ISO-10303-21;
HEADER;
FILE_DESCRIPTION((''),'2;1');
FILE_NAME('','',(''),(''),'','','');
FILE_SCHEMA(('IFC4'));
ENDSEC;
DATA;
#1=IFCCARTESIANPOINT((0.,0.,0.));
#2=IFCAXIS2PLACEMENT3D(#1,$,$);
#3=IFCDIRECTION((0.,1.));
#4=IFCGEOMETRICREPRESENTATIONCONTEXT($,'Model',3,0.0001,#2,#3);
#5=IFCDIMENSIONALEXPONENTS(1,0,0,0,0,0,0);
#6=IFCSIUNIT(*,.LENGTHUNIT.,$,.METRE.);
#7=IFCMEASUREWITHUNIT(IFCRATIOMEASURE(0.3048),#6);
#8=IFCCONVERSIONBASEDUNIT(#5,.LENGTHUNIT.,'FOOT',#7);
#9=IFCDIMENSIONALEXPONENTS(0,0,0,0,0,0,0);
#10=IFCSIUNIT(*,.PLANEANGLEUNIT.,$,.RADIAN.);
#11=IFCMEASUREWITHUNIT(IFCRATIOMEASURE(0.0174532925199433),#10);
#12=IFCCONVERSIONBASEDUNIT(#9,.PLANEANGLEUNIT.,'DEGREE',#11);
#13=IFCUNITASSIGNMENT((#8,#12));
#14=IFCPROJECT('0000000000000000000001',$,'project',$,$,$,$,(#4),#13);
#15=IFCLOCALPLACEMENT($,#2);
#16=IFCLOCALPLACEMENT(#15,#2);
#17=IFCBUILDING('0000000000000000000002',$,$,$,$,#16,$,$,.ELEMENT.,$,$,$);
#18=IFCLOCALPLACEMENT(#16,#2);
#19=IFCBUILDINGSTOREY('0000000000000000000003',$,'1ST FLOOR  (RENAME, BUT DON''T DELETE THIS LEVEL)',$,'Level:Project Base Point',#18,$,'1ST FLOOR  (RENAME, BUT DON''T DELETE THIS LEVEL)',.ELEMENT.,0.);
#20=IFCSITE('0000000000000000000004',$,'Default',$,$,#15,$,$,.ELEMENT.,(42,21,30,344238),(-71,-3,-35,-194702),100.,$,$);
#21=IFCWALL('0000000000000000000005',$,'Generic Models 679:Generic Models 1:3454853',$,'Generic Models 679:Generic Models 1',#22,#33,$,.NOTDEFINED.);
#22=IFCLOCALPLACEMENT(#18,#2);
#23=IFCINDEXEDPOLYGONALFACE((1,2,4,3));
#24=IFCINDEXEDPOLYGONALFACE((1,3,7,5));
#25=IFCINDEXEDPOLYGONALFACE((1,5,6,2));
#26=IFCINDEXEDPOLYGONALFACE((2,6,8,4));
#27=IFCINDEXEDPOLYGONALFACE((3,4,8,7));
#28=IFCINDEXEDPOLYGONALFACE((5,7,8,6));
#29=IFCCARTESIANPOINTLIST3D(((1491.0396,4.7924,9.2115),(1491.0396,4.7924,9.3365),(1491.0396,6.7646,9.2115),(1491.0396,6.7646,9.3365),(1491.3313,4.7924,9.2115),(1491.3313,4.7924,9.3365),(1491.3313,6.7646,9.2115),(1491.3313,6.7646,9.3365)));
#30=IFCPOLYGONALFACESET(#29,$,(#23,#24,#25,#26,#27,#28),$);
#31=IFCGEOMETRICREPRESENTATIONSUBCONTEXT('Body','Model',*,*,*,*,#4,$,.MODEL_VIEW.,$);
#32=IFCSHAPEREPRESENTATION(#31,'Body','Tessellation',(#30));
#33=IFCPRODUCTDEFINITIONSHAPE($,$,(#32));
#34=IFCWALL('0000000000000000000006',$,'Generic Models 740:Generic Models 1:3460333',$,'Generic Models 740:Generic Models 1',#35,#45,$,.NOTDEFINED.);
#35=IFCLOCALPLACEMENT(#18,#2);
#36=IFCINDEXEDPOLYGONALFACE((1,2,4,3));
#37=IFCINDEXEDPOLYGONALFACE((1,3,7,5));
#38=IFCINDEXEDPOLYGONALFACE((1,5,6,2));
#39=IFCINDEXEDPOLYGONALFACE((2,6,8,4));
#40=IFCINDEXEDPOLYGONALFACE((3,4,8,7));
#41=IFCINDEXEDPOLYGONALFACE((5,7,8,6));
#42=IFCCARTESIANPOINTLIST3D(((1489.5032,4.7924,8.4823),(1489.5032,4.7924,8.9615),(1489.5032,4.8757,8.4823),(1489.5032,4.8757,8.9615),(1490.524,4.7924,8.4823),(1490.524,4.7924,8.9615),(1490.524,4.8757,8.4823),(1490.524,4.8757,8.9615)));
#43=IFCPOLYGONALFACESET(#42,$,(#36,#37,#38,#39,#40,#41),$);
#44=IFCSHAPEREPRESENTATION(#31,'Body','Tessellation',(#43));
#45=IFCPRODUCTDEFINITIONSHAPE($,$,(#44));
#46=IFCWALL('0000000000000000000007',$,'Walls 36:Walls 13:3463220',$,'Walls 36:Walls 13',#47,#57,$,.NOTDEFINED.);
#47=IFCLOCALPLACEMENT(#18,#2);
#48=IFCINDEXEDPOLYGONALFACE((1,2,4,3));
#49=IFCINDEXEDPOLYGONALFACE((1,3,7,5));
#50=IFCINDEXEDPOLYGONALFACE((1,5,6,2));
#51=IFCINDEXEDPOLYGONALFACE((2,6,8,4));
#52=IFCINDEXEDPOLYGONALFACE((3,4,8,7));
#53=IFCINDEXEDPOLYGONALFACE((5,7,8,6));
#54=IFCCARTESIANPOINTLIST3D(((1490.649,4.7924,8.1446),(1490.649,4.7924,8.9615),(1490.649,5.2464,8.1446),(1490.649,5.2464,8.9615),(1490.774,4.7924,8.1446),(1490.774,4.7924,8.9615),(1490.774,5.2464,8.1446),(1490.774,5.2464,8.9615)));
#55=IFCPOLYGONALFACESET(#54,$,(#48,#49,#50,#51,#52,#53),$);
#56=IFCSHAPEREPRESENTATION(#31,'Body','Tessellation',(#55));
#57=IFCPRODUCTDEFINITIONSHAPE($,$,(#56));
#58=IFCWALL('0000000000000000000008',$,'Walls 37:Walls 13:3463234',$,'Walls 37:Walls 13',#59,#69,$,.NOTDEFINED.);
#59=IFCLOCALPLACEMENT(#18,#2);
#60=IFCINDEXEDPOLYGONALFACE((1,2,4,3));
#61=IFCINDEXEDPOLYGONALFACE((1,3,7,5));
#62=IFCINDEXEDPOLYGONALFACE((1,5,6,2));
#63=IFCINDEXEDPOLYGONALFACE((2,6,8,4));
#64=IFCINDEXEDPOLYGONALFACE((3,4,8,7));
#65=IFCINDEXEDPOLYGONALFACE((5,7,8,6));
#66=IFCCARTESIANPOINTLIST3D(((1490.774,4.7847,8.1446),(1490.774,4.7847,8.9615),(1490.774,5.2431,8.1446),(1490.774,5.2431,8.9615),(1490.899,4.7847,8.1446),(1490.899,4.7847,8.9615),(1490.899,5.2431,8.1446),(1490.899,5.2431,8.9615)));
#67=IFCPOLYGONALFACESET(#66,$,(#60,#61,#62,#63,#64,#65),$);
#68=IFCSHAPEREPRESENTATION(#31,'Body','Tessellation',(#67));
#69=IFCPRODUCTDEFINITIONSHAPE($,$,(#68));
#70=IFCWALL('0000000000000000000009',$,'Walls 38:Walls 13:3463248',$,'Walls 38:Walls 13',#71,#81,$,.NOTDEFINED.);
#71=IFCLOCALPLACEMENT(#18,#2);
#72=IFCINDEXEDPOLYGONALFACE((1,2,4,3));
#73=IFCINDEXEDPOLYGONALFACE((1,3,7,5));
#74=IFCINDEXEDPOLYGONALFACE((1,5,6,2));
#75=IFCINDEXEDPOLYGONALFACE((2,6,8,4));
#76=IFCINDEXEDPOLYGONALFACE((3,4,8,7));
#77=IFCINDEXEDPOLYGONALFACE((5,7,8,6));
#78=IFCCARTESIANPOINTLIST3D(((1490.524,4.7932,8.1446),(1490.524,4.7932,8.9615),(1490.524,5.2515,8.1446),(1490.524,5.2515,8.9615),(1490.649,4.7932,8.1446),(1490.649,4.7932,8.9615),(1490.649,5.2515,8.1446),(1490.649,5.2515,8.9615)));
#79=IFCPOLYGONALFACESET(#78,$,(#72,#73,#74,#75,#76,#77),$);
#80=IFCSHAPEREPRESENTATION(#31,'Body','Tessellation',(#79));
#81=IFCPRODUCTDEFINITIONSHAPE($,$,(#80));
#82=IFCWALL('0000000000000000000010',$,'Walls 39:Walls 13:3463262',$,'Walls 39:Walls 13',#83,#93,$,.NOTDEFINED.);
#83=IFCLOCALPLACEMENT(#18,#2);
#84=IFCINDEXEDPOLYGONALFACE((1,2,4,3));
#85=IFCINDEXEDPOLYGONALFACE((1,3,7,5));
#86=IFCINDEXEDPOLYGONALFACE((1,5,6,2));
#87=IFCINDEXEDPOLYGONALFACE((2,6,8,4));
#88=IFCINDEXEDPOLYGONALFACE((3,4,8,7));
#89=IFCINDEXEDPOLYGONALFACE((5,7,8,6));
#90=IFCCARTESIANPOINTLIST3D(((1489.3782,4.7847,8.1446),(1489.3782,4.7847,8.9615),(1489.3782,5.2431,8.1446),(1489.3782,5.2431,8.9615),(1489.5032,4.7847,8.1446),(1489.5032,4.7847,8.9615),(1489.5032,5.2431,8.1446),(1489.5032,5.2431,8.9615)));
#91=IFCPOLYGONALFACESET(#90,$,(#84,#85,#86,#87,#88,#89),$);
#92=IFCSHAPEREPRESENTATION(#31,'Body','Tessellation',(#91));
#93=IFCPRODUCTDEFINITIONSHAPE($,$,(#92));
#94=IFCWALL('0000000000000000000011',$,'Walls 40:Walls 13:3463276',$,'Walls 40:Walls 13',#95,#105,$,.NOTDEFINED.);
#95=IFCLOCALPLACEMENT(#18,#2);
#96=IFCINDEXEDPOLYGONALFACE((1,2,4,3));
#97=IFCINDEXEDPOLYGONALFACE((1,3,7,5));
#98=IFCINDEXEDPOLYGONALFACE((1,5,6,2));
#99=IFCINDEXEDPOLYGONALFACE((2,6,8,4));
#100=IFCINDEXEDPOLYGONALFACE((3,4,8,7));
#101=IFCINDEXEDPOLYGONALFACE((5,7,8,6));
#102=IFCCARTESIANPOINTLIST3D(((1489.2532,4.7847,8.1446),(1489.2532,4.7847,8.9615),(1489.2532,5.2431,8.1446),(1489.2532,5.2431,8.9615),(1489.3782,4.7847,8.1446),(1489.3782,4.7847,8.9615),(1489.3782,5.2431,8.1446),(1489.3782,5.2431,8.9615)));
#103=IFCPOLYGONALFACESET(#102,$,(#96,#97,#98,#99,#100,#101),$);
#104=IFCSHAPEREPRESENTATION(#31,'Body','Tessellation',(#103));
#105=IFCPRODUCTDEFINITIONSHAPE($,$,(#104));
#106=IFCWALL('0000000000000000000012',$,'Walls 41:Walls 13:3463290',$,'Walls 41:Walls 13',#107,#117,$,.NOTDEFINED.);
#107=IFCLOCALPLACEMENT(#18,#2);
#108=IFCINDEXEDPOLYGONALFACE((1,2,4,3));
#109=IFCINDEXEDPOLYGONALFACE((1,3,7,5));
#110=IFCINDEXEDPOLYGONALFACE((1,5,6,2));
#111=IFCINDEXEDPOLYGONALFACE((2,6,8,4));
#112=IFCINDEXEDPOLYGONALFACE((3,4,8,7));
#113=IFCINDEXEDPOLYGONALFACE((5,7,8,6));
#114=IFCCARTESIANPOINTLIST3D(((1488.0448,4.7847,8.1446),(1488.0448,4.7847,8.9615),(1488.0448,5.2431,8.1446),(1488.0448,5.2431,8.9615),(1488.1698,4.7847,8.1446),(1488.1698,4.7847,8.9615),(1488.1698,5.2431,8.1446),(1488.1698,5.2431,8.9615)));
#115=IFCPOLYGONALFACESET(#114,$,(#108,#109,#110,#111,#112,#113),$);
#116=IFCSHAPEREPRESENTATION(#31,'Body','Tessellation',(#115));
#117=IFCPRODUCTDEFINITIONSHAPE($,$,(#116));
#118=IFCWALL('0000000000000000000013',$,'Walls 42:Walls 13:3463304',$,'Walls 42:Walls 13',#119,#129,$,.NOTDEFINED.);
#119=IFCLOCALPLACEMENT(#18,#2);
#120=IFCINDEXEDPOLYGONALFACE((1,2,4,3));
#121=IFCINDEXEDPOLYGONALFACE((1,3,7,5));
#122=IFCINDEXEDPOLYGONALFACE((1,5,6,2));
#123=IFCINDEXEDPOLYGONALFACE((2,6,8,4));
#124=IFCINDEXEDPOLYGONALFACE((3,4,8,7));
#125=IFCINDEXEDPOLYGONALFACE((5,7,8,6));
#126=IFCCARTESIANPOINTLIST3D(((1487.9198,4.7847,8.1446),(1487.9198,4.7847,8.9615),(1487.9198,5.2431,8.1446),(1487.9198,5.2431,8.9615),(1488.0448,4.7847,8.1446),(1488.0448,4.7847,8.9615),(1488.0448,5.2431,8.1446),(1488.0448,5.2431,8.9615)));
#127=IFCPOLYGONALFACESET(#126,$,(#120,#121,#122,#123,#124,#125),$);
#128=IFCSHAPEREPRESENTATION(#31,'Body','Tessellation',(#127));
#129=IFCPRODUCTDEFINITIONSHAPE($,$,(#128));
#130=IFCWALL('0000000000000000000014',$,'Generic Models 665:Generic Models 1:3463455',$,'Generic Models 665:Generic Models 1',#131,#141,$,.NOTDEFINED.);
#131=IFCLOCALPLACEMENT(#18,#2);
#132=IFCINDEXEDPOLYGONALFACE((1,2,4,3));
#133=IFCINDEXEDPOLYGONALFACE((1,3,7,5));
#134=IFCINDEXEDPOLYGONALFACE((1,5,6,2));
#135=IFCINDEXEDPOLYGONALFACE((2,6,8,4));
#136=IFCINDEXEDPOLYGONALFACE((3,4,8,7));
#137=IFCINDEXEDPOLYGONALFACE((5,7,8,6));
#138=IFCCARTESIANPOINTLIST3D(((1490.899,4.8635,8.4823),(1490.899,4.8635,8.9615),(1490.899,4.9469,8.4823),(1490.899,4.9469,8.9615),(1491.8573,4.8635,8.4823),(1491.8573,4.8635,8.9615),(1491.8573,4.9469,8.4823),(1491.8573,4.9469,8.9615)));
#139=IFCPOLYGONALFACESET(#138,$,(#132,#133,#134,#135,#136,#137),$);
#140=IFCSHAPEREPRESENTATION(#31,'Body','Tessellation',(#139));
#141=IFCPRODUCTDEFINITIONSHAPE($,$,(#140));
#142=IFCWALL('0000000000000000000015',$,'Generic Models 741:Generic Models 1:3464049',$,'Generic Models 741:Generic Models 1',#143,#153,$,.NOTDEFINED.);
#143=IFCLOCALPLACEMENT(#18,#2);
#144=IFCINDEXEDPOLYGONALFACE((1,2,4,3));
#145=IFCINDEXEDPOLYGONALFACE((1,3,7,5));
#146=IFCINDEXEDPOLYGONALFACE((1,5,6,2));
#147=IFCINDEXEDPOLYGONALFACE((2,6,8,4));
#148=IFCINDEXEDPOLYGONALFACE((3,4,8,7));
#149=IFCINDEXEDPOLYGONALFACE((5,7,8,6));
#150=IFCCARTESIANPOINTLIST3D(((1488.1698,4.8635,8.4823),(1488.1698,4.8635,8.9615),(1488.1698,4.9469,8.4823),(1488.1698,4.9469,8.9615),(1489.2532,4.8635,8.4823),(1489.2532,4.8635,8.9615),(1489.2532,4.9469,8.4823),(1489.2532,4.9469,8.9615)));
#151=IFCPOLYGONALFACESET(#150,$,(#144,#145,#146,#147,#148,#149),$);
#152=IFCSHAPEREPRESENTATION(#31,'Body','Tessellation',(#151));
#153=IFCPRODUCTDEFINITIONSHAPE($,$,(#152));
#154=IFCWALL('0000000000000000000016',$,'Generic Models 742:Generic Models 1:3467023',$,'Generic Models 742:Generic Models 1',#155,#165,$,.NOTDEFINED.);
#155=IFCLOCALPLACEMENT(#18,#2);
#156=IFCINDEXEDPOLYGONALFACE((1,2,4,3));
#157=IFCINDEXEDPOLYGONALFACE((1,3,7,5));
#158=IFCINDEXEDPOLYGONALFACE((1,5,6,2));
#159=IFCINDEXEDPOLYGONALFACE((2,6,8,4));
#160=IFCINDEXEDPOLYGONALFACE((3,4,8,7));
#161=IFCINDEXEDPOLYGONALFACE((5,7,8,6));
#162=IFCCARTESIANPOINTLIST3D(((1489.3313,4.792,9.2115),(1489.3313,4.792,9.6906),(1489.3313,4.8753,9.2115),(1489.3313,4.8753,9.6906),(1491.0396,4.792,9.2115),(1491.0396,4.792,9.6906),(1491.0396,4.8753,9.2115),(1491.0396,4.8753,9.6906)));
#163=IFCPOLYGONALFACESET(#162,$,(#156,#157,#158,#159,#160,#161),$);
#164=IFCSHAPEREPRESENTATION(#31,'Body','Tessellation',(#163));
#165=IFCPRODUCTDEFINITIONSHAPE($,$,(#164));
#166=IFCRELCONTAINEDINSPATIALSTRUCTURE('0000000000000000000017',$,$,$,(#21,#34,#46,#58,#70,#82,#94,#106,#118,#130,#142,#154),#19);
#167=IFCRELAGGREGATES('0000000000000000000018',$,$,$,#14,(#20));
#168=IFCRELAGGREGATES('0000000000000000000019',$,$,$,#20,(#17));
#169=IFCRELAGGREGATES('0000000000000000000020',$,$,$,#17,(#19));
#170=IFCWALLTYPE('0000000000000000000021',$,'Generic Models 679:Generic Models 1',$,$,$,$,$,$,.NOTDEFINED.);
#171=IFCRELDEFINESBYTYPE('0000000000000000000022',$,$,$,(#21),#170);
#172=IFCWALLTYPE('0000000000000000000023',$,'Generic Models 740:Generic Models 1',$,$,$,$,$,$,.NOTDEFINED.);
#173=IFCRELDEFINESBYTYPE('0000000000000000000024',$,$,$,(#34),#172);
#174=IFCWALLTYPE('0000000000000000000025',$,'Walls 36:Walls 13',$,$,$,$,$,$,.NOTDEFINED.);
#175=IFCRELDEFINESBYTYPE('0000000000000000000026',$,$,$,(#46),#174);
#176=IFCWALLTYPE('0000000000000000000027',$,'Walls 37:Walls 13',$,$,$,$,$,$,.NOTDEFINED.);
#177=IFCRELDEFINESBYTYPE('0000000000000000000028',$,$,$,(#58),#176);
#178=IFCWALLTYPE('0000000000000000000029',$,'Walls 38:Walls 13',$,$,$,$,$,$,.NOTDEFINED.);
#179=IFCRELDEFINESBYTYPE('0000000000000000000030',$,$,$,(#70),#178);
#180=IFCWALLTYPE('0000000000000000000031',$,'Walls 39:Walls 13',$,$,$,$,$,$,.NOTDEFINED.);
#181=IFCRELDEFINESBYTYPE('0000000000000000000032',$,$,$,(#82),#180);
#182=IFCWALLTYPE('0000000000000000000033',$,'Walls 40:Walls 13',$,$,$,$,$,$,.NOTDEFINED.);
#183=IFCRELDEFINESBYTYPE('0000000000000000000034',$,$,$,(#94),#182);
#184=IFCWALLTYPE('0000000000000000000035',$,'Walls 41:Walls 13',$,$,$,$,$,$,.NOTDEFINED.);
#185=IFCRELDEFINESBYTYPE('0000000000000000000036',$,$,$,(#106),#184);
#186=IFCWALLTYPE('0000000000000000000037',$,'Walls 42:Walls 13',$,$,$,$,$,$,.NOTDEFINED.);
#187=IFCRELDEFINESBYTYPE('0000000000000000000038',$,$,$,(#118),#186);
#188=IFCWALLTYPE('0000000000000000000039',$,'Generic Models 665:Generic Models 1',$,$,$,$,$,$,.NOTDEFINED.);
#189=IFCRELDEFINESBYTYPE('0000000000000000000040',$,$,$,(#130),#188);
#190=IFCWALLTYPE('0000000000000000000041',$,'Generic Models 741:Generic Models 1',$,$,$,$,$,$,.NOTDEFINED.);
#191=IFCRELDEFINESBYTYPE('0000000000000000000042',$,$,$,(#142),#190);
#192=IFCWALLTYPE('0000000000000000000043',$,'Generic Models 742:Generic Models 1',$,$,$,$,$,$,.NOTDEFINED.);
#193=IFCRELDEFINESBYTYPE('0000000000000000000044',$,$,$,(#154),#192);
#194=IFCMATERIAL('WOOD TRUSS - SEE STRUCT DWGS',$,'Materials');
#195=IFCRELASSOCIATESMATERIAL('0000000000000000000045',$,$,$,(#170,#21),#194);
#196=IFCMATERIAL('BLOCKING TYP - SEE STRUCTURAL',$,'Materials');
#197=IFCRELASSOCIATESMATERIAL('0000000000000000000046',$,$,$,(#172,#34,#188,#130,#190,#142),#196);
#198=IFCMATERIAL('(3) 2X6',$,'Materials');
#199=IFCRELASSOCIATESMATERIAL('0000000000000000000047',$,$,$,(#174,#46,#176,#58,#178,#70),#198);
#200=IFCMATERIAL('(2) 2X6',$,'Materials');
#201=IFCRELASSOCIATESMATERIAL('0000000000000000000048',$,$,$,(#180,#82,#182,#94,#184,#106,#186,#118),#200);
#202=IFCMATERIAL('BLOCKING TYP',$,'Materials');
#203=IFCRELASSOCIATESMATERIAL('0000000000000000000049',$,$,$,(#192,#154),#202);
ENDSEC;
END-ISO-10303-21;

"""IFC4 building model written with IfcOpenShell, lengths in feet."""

from ifc_helpers import new_model, entity, si_unit, converted_unit, direction, frame, frame_2d, origin, origin_2d_with_axis, place, context, subcontext, project, spatial, rectangle, extrude, material, type_object, element, save


model = new_model("IFC4")

# Units and contexts
model_context = context("Model", 3, precision=0.0001, world=origin(), true_north=direction((0.0, 1.0)))
body_context = subcontext(model_context, "Body", "Model", "MODEL_VIEW")
ifc_project = project(units=[converted_unit("LENGTHUNIT", "FOOT", entity("IfcRatioMeasure", 0.3048), si_unit("LENGTHUNIT", "METRE"), dimensions=[1, 0, 0, 0, 0, 0, 0]), converted_unit("PLANEANGLEUNIT", "DEGREE", entity("IfcRatioMeasure", 0.0174532925199433), si_unit("PLANEANGLEUNIT", "RADIAN"), dimensions=[0, 0, 0, 0, 0, 0, 0])], contexts=[model_context])

# Site, building, storey
site_placement = place(None, origin())
site = spatial("IfcSite", under=ifc_project, at=site_placement, Name="Default", CompositionType="ELEMENT", RefLatitude=(42, 21, 30, 344238), RefLongitude=(-71, -3, -35, -194702), RefElevation=100.0)
building_placement = place(site_placement, origin())
building = spatial("IfcBuilding", under=site, at=building_placement, CompositionType="ELEMENT")
storey_placement = place(building_placement, origin())
storey = spatial("IfcBuildingStorey", under=building, at=storey_placement, Name="1ST FLOOR  (RENAME, BUT DON'T DELETE THIS LEVEL)", ObjectType="Level:Project Base Point", LongName="1ST FLOOR  (RENAME, BUT DON'T DELETE THIS LEVEL)", CompositionType="ELEMENT", Elevation=0.0)

# Walls
ifc_material_1 = material(Name="WOOD TRUSS - SEE STRUCT DWGS", Category="Materials")
wall_type_1 = type_object("IfcWallType", Name="Generic Models 679:Generic Models 1", PredefinedType="NOTDEFINED", material=ifc_material_1)
wall_1_placement = place(storey_placement, frame((1491.0396, 4.7924, 9.2115), z_axis=(0.0, 0.0, 1.0), x_axis=(0.0, 1.0, 0.0)))
element("IfcWall", 1, at=wall_1_placement, inside=storey, type_object=wall_type_1, material=ifc_material_1, Name="Generic Models 679:Generic Models 1:3454853", ObjectType="Generic Models 679:Generic Models 1", PredefinedType="NOTDEFINED", context=body_context, shape_type="SweptSolid", body=[
    extrude(rectangle(XDim=1.9723, YDim=0.2917, at=origin_2d_with_axis()), frame((0.9861, -0.1458, 0.0)), (0.0, 0.0, 1.0), 0.125),
])
ifc_material_2 = material(Name="BLOCKING TYP - SEE STRUCTURAL", Category="Materials")
wall_type_2 = type_object("IfcWallType", Name="Generic Models 740:Generic Models 1", PredefinedType="NOTDEFINED", material=ifc_material_2)
wall_2_placement = place(storey_placement, frame((1489.5032, 4.7924, 8.4823)))
element("IfcWall", 2, at=wall_2_placement, inside=storey, type_object=wall_type_2, material=ifc_material_2, Name="Generic Models 740:Generic Models 1:3460333", ObjectType="Generic Models 740:Generic Models 1", PredefinedType="NOTDEFINED", context=body_context, shape_type="SweptSolid", body=[
    extrude(rectangle(XDim=0.0833, YDim=1.0208, at=frame_2d((0.0, 0.0), x_axis=(1.0, 0.0))), frame((0.5104, 0.0417, 0.0), z_axis=(0.0, 0.0, 1.0), x_axis=(0.0, 1.0, 0.0)), (0.0, 0.0, 1.0), 0.4792),
])
ifc_material_3 = material(Name="(3) 2X6", Category="Materials")
wall_type_3 = type_object("IfcWallType", Name="Walls 36:Walls 13", PredefinedType="NOTDEFINED", material=ifc_material_3)
wall_3_placement = place(storey_placement, frame((1490.649, 4.7924, 8.1446), z_axis=(0.0, 0.0, 1.0), x_axis=(0.0, 1.0, 0.0)))
element("IfcWall", 3, at=wall_3_placement, inside=storey, type_object=wall_type_3, material=ifc_material_3, Name="Walls 36:Walls 13:3463220", ObjectType="Walls 36:Walls 13", PredefinedType="NOTDEFINED", context=body_context, shape_type="SweptSolid", body=[
    extrude(rectangle(XDim=0.454, YDim=0.125, at=frame_2d((0.0, 0.0), x_axis=(1.0, 0.0))), frame((0.227, -0.0625, 0.0)), (0.0, 0.0, 1.0), 0.8169),
])
wall_type_4 = type_object("IfcWallType", Name="Walls 37:Walls 13", PredefinedType="NOTDEFINED", material=ifc_material_3)
wall_4_placement = place(storey_placement, frame((1490.774, 4.7847, 8.1446), z_axis=(0.0, 0.0, 1.0), x_axis=(0.0, 1.0, 0.0)))
element("IfcWall", 4, at=wall_4_placement, inside=storey, type_object=wall_type_4, material=ifc_material_3, Name="Walls 37:Walls 13:3463234", ObjectType="Walls 37:Walls 13", PredefinedType="NOTDEFINED", context=body_context, shape_type="SweptSolid", body=[
    extrude(rectangle(XDim=0.4583, YDim=0.125, at=origin_2d_with_axis()), frame((0.2292, -0.0625, 0.0)), (0.0, 0.0, 1.0), 0.8169),
])
wall_type_5 = type_object("IfcWallType", Name="Walls 38:Walls 13", PredefinedType="NOTDEFINED", material=ifc_material_3)
wall_5_placement = place(storey_placement, frame((1490.524, 4.7932, 8.1446), z_axis=(0.0, 0.0, 1.0), x_axis=(0.0, 1.0, 0.0)))
element("IfcWall", 5, at=wall_5_placement, inside=storey, type_object=wall_type_5, material=ifc_material_3, Name="Walls 38:Walls 13:3463248", ObjectType="Walls 38:Walls 13", PredefinedType="NOTDEFINED", context=body_context, shape_type="SweptSolid", body=[
    extrude(rectangle(XDim=0.4583, YDim=0.125, at=frame_2d((0.0, 0.0), x_axis=(1.0, 0.0))), frame((0.2292, -0.0625, 0.0)), (0.0, 0.0, 1.0), 0.8169),
])
ifc_material_4 = material(Name="(2) 2X6", Category="Materials")
wall_type_6 = type_object("IfcWallType", Name="Walls 39:Walls 13", PredefinedType="NOTDEFINED", material=ifc_material_4)
wall_6_placement = place(storey_placement, frame((1489.3782, 4.7847, 8.1446), z_axis=(0.0, 0.0, 1.0), x_axis=(0.0, 1.0, 0.0)))
element("IfcWall", 6, at=wall_6_placement, inside=storey, type_object=wall_type_6, material=ifc_material_4, Name="Walls 39:Walls 13:3463262", ObjectType="Walls 39:Walls 13", PredefinedType="NOTDEFINED", context=body_context, shape_type="SweptSolid", body=[
    extrude(rectangle(XDim=0.4583, YDim=0.125, at=frame_2d((0.0, 0.0), x_axis=(1.0, 0.0))), frame((0.2292, -0.0625, 0.0)), (0.0, 0.0, 1.0), 0.8169),
])
wall_type_7 = type_object("IfcWallType", Name="Walls 40:Walls 13", PredefinedType="NOTDEFINED", material=ifc_material_4)
wall_7_placement = place(storey_placement, frame((1489.2532, 4.7847, 8.1446), z_axis=(0.0, 0.0, 1.0), x_axis=(0.0, 1.0, 0.0)))
element("IfcWall", 7, at=wall_7_placement, inside=storey, type_object=wall_type_7, material=ifc_material_4, Name="Walls 40:Walls 13:3463276", ObjectType="Walls 40:Walls 13", PredefinedType="NOTDEFINED", context=body_context, shape_type="SweptSolid", body=[
    extrude(rectangle(XDim=0.4583, YDim=0.125, at=frame_2d((0.0, 0.0), x_axis=(1.0, 0.0))), frame((0.2292, -0.0625, 0.0)), (0.0, 0.0, 1.0), 0.8169),
])
wall_type_8 = type_object("IfcWallType", Name="Walls 41:Walls 13", PredefinedType="NOTDEFINED", material=ifc_material_4)
wall_8_placement = place(storey_placement, frame((1488.0448, 4.7847, 8.1446), z_axis=(0.0, 0.0, 1.0), x_axis=(0.0, 1.0, 0.0)))
element("IfcWall", 8, at=wall_8_placement, inside=storey, type_object=wall_type_8, material=ifc_material_4, Name="Walls 41:Walls 13:3463290", ObjectType="Walls 41:Walls 13", PredefinedType="NOTDEFINED", context=body_context, shape_type="SweptSolid", body=[
    extrude(rectangle(XDim=0.4583, YDim=0.125, at=origin_2d_with_axis()), frame((0.2292, -0.0625, 0.0)), (0.0, 0.0, 1.0), 0.8169),
])
wall_type_9 = type_object("IfcWallType", Name="Walls 42:Walls 13", PredefinedType="NOTDEFINED", material=ifc_material_4)
wall_9_placement = place(storey_placement, frame((1487.9198, 4.7847, 8.1446), z_axis=(0.0, 0.0, 1.0), x_axis=(0.0, 1.0, 0.0)))
element("IfcWall", 9, at=wall_9_placement, inside=storey, type_object=wall_type_9, material=ifc_material_4, Name="Walls 42:Walls 13:3463304", ObjectType="Walls 42:Walls 13", PredefinedType="NOTDEFINED", context=body_context, shape_type="SweptSolid", body=[
    extrude(rectangle(XDim=0.4583, YDim=0.125, at=frame_2d((0.0, 0.0), x_axis=(1.0, 0.0))), frame((0.2292, -0.0625, 0.0)), (0.0, 0.0, 1.0), 0.8169),
])
wall_type_10 = type_object("IfcWallType", Name="Generic Models 665:Generic Models 1", PredefinedType="NOTDEFINED", material=ifc_material_2)
wall_10_placement = place(storey_placement, frame((1490.899, 4.8635, 8.4823)))
element("IfcWall", 10, at=wall_10_placement, inside=storey, type_object=wall_type_10, material=ifc_material_2, Name="Generic Models 665:Generic Models 1:3463455", ObjectType="Generic Models 665:Generic Models 1", PredefinedType="NOTDEFINED", context=body_context, shape_type="SweptSolid", body=[
    extrude(rectangle(XDim=0.0833, YDim=0.9583, at=frame_2d((0.0, 0.0), x_axis=(1.0, 0.0))), frame((0.4792, 0.0417, 0.0), z_axis=(0.0, 0.0, 1.0), x_axis=(0.0, 1.0, 0.0)), (0.0, 0.0, 1.0), 0.4792),
])
wall_type_11 = type_object("IfcWallType", Name="Generic Models 741:Generic Models 1", PredefinedType="NOTDEFINED", material=ifc_material_2)
wall_11_placement = place(storey_placement, frame((1488.1698, 4.8635, 8.4823)))
element("IfcWall", 11, at=wall_11_placement, inside=storey, type_object=wall_type_11, material=ifc_material_2, Name="Generic Models 741:Generic Models 1:3464049", ObjectType="Generic Models 741:Generic Models 1", PredefinedType="NOTDEFINED", context=body_context, shape_type="SweptSolid", body=[
    extrude(rectangle(XDim=0.0833, YDim=1.0833, at=frame_2d((0.0, 0.0), x_axis=(1.0, 0.0))), frame((0.5417, 0.0417, 0.0), z_axis=(0.0, 0.0, 1.0), x_axis=(0.0, 1.0, 0.0)), (0.0, 0.0, 1.0), 0.4792),
])
ifc_material_5 = material(Name="BLOCKING TYP", Category="Materials")
wall_type_12 = type_object("IfcWallType", Name="Generic Models 742:Generic Models 1", PredefinedType="NOTDEFINED", material=ifc_material_5)
wall_12_placement = place(storey_placement, frame((1489.3313, 4.792, 9.2115)))
element("IfcWall", 12, at=wall_12_placement, inside=storey, type_object=wall_type_12, material=ifc_material_5, Name="Generic Models 742:Generic Models 1:3467023", ObjectType="Generic Models 742:Generic Models 1", PredefinedType="NOTDEFINED", context=body_context, shape_type="SweptSolid", body=[
    extrude(rectangle(XDim=0.0833, YDim=1.7083, at=frame_2d((0.0, 0.0), x_axis=(1.0, 0.0))), frame((0.8542, 0.0417, 0.0), z_axis=(0.0, 0.0, 1.0), x_axis=(0.0, 1.0, 0.0)), (0.0, 0.0, 1.0), 0.4792),
])

save(model, "model.ifc")
